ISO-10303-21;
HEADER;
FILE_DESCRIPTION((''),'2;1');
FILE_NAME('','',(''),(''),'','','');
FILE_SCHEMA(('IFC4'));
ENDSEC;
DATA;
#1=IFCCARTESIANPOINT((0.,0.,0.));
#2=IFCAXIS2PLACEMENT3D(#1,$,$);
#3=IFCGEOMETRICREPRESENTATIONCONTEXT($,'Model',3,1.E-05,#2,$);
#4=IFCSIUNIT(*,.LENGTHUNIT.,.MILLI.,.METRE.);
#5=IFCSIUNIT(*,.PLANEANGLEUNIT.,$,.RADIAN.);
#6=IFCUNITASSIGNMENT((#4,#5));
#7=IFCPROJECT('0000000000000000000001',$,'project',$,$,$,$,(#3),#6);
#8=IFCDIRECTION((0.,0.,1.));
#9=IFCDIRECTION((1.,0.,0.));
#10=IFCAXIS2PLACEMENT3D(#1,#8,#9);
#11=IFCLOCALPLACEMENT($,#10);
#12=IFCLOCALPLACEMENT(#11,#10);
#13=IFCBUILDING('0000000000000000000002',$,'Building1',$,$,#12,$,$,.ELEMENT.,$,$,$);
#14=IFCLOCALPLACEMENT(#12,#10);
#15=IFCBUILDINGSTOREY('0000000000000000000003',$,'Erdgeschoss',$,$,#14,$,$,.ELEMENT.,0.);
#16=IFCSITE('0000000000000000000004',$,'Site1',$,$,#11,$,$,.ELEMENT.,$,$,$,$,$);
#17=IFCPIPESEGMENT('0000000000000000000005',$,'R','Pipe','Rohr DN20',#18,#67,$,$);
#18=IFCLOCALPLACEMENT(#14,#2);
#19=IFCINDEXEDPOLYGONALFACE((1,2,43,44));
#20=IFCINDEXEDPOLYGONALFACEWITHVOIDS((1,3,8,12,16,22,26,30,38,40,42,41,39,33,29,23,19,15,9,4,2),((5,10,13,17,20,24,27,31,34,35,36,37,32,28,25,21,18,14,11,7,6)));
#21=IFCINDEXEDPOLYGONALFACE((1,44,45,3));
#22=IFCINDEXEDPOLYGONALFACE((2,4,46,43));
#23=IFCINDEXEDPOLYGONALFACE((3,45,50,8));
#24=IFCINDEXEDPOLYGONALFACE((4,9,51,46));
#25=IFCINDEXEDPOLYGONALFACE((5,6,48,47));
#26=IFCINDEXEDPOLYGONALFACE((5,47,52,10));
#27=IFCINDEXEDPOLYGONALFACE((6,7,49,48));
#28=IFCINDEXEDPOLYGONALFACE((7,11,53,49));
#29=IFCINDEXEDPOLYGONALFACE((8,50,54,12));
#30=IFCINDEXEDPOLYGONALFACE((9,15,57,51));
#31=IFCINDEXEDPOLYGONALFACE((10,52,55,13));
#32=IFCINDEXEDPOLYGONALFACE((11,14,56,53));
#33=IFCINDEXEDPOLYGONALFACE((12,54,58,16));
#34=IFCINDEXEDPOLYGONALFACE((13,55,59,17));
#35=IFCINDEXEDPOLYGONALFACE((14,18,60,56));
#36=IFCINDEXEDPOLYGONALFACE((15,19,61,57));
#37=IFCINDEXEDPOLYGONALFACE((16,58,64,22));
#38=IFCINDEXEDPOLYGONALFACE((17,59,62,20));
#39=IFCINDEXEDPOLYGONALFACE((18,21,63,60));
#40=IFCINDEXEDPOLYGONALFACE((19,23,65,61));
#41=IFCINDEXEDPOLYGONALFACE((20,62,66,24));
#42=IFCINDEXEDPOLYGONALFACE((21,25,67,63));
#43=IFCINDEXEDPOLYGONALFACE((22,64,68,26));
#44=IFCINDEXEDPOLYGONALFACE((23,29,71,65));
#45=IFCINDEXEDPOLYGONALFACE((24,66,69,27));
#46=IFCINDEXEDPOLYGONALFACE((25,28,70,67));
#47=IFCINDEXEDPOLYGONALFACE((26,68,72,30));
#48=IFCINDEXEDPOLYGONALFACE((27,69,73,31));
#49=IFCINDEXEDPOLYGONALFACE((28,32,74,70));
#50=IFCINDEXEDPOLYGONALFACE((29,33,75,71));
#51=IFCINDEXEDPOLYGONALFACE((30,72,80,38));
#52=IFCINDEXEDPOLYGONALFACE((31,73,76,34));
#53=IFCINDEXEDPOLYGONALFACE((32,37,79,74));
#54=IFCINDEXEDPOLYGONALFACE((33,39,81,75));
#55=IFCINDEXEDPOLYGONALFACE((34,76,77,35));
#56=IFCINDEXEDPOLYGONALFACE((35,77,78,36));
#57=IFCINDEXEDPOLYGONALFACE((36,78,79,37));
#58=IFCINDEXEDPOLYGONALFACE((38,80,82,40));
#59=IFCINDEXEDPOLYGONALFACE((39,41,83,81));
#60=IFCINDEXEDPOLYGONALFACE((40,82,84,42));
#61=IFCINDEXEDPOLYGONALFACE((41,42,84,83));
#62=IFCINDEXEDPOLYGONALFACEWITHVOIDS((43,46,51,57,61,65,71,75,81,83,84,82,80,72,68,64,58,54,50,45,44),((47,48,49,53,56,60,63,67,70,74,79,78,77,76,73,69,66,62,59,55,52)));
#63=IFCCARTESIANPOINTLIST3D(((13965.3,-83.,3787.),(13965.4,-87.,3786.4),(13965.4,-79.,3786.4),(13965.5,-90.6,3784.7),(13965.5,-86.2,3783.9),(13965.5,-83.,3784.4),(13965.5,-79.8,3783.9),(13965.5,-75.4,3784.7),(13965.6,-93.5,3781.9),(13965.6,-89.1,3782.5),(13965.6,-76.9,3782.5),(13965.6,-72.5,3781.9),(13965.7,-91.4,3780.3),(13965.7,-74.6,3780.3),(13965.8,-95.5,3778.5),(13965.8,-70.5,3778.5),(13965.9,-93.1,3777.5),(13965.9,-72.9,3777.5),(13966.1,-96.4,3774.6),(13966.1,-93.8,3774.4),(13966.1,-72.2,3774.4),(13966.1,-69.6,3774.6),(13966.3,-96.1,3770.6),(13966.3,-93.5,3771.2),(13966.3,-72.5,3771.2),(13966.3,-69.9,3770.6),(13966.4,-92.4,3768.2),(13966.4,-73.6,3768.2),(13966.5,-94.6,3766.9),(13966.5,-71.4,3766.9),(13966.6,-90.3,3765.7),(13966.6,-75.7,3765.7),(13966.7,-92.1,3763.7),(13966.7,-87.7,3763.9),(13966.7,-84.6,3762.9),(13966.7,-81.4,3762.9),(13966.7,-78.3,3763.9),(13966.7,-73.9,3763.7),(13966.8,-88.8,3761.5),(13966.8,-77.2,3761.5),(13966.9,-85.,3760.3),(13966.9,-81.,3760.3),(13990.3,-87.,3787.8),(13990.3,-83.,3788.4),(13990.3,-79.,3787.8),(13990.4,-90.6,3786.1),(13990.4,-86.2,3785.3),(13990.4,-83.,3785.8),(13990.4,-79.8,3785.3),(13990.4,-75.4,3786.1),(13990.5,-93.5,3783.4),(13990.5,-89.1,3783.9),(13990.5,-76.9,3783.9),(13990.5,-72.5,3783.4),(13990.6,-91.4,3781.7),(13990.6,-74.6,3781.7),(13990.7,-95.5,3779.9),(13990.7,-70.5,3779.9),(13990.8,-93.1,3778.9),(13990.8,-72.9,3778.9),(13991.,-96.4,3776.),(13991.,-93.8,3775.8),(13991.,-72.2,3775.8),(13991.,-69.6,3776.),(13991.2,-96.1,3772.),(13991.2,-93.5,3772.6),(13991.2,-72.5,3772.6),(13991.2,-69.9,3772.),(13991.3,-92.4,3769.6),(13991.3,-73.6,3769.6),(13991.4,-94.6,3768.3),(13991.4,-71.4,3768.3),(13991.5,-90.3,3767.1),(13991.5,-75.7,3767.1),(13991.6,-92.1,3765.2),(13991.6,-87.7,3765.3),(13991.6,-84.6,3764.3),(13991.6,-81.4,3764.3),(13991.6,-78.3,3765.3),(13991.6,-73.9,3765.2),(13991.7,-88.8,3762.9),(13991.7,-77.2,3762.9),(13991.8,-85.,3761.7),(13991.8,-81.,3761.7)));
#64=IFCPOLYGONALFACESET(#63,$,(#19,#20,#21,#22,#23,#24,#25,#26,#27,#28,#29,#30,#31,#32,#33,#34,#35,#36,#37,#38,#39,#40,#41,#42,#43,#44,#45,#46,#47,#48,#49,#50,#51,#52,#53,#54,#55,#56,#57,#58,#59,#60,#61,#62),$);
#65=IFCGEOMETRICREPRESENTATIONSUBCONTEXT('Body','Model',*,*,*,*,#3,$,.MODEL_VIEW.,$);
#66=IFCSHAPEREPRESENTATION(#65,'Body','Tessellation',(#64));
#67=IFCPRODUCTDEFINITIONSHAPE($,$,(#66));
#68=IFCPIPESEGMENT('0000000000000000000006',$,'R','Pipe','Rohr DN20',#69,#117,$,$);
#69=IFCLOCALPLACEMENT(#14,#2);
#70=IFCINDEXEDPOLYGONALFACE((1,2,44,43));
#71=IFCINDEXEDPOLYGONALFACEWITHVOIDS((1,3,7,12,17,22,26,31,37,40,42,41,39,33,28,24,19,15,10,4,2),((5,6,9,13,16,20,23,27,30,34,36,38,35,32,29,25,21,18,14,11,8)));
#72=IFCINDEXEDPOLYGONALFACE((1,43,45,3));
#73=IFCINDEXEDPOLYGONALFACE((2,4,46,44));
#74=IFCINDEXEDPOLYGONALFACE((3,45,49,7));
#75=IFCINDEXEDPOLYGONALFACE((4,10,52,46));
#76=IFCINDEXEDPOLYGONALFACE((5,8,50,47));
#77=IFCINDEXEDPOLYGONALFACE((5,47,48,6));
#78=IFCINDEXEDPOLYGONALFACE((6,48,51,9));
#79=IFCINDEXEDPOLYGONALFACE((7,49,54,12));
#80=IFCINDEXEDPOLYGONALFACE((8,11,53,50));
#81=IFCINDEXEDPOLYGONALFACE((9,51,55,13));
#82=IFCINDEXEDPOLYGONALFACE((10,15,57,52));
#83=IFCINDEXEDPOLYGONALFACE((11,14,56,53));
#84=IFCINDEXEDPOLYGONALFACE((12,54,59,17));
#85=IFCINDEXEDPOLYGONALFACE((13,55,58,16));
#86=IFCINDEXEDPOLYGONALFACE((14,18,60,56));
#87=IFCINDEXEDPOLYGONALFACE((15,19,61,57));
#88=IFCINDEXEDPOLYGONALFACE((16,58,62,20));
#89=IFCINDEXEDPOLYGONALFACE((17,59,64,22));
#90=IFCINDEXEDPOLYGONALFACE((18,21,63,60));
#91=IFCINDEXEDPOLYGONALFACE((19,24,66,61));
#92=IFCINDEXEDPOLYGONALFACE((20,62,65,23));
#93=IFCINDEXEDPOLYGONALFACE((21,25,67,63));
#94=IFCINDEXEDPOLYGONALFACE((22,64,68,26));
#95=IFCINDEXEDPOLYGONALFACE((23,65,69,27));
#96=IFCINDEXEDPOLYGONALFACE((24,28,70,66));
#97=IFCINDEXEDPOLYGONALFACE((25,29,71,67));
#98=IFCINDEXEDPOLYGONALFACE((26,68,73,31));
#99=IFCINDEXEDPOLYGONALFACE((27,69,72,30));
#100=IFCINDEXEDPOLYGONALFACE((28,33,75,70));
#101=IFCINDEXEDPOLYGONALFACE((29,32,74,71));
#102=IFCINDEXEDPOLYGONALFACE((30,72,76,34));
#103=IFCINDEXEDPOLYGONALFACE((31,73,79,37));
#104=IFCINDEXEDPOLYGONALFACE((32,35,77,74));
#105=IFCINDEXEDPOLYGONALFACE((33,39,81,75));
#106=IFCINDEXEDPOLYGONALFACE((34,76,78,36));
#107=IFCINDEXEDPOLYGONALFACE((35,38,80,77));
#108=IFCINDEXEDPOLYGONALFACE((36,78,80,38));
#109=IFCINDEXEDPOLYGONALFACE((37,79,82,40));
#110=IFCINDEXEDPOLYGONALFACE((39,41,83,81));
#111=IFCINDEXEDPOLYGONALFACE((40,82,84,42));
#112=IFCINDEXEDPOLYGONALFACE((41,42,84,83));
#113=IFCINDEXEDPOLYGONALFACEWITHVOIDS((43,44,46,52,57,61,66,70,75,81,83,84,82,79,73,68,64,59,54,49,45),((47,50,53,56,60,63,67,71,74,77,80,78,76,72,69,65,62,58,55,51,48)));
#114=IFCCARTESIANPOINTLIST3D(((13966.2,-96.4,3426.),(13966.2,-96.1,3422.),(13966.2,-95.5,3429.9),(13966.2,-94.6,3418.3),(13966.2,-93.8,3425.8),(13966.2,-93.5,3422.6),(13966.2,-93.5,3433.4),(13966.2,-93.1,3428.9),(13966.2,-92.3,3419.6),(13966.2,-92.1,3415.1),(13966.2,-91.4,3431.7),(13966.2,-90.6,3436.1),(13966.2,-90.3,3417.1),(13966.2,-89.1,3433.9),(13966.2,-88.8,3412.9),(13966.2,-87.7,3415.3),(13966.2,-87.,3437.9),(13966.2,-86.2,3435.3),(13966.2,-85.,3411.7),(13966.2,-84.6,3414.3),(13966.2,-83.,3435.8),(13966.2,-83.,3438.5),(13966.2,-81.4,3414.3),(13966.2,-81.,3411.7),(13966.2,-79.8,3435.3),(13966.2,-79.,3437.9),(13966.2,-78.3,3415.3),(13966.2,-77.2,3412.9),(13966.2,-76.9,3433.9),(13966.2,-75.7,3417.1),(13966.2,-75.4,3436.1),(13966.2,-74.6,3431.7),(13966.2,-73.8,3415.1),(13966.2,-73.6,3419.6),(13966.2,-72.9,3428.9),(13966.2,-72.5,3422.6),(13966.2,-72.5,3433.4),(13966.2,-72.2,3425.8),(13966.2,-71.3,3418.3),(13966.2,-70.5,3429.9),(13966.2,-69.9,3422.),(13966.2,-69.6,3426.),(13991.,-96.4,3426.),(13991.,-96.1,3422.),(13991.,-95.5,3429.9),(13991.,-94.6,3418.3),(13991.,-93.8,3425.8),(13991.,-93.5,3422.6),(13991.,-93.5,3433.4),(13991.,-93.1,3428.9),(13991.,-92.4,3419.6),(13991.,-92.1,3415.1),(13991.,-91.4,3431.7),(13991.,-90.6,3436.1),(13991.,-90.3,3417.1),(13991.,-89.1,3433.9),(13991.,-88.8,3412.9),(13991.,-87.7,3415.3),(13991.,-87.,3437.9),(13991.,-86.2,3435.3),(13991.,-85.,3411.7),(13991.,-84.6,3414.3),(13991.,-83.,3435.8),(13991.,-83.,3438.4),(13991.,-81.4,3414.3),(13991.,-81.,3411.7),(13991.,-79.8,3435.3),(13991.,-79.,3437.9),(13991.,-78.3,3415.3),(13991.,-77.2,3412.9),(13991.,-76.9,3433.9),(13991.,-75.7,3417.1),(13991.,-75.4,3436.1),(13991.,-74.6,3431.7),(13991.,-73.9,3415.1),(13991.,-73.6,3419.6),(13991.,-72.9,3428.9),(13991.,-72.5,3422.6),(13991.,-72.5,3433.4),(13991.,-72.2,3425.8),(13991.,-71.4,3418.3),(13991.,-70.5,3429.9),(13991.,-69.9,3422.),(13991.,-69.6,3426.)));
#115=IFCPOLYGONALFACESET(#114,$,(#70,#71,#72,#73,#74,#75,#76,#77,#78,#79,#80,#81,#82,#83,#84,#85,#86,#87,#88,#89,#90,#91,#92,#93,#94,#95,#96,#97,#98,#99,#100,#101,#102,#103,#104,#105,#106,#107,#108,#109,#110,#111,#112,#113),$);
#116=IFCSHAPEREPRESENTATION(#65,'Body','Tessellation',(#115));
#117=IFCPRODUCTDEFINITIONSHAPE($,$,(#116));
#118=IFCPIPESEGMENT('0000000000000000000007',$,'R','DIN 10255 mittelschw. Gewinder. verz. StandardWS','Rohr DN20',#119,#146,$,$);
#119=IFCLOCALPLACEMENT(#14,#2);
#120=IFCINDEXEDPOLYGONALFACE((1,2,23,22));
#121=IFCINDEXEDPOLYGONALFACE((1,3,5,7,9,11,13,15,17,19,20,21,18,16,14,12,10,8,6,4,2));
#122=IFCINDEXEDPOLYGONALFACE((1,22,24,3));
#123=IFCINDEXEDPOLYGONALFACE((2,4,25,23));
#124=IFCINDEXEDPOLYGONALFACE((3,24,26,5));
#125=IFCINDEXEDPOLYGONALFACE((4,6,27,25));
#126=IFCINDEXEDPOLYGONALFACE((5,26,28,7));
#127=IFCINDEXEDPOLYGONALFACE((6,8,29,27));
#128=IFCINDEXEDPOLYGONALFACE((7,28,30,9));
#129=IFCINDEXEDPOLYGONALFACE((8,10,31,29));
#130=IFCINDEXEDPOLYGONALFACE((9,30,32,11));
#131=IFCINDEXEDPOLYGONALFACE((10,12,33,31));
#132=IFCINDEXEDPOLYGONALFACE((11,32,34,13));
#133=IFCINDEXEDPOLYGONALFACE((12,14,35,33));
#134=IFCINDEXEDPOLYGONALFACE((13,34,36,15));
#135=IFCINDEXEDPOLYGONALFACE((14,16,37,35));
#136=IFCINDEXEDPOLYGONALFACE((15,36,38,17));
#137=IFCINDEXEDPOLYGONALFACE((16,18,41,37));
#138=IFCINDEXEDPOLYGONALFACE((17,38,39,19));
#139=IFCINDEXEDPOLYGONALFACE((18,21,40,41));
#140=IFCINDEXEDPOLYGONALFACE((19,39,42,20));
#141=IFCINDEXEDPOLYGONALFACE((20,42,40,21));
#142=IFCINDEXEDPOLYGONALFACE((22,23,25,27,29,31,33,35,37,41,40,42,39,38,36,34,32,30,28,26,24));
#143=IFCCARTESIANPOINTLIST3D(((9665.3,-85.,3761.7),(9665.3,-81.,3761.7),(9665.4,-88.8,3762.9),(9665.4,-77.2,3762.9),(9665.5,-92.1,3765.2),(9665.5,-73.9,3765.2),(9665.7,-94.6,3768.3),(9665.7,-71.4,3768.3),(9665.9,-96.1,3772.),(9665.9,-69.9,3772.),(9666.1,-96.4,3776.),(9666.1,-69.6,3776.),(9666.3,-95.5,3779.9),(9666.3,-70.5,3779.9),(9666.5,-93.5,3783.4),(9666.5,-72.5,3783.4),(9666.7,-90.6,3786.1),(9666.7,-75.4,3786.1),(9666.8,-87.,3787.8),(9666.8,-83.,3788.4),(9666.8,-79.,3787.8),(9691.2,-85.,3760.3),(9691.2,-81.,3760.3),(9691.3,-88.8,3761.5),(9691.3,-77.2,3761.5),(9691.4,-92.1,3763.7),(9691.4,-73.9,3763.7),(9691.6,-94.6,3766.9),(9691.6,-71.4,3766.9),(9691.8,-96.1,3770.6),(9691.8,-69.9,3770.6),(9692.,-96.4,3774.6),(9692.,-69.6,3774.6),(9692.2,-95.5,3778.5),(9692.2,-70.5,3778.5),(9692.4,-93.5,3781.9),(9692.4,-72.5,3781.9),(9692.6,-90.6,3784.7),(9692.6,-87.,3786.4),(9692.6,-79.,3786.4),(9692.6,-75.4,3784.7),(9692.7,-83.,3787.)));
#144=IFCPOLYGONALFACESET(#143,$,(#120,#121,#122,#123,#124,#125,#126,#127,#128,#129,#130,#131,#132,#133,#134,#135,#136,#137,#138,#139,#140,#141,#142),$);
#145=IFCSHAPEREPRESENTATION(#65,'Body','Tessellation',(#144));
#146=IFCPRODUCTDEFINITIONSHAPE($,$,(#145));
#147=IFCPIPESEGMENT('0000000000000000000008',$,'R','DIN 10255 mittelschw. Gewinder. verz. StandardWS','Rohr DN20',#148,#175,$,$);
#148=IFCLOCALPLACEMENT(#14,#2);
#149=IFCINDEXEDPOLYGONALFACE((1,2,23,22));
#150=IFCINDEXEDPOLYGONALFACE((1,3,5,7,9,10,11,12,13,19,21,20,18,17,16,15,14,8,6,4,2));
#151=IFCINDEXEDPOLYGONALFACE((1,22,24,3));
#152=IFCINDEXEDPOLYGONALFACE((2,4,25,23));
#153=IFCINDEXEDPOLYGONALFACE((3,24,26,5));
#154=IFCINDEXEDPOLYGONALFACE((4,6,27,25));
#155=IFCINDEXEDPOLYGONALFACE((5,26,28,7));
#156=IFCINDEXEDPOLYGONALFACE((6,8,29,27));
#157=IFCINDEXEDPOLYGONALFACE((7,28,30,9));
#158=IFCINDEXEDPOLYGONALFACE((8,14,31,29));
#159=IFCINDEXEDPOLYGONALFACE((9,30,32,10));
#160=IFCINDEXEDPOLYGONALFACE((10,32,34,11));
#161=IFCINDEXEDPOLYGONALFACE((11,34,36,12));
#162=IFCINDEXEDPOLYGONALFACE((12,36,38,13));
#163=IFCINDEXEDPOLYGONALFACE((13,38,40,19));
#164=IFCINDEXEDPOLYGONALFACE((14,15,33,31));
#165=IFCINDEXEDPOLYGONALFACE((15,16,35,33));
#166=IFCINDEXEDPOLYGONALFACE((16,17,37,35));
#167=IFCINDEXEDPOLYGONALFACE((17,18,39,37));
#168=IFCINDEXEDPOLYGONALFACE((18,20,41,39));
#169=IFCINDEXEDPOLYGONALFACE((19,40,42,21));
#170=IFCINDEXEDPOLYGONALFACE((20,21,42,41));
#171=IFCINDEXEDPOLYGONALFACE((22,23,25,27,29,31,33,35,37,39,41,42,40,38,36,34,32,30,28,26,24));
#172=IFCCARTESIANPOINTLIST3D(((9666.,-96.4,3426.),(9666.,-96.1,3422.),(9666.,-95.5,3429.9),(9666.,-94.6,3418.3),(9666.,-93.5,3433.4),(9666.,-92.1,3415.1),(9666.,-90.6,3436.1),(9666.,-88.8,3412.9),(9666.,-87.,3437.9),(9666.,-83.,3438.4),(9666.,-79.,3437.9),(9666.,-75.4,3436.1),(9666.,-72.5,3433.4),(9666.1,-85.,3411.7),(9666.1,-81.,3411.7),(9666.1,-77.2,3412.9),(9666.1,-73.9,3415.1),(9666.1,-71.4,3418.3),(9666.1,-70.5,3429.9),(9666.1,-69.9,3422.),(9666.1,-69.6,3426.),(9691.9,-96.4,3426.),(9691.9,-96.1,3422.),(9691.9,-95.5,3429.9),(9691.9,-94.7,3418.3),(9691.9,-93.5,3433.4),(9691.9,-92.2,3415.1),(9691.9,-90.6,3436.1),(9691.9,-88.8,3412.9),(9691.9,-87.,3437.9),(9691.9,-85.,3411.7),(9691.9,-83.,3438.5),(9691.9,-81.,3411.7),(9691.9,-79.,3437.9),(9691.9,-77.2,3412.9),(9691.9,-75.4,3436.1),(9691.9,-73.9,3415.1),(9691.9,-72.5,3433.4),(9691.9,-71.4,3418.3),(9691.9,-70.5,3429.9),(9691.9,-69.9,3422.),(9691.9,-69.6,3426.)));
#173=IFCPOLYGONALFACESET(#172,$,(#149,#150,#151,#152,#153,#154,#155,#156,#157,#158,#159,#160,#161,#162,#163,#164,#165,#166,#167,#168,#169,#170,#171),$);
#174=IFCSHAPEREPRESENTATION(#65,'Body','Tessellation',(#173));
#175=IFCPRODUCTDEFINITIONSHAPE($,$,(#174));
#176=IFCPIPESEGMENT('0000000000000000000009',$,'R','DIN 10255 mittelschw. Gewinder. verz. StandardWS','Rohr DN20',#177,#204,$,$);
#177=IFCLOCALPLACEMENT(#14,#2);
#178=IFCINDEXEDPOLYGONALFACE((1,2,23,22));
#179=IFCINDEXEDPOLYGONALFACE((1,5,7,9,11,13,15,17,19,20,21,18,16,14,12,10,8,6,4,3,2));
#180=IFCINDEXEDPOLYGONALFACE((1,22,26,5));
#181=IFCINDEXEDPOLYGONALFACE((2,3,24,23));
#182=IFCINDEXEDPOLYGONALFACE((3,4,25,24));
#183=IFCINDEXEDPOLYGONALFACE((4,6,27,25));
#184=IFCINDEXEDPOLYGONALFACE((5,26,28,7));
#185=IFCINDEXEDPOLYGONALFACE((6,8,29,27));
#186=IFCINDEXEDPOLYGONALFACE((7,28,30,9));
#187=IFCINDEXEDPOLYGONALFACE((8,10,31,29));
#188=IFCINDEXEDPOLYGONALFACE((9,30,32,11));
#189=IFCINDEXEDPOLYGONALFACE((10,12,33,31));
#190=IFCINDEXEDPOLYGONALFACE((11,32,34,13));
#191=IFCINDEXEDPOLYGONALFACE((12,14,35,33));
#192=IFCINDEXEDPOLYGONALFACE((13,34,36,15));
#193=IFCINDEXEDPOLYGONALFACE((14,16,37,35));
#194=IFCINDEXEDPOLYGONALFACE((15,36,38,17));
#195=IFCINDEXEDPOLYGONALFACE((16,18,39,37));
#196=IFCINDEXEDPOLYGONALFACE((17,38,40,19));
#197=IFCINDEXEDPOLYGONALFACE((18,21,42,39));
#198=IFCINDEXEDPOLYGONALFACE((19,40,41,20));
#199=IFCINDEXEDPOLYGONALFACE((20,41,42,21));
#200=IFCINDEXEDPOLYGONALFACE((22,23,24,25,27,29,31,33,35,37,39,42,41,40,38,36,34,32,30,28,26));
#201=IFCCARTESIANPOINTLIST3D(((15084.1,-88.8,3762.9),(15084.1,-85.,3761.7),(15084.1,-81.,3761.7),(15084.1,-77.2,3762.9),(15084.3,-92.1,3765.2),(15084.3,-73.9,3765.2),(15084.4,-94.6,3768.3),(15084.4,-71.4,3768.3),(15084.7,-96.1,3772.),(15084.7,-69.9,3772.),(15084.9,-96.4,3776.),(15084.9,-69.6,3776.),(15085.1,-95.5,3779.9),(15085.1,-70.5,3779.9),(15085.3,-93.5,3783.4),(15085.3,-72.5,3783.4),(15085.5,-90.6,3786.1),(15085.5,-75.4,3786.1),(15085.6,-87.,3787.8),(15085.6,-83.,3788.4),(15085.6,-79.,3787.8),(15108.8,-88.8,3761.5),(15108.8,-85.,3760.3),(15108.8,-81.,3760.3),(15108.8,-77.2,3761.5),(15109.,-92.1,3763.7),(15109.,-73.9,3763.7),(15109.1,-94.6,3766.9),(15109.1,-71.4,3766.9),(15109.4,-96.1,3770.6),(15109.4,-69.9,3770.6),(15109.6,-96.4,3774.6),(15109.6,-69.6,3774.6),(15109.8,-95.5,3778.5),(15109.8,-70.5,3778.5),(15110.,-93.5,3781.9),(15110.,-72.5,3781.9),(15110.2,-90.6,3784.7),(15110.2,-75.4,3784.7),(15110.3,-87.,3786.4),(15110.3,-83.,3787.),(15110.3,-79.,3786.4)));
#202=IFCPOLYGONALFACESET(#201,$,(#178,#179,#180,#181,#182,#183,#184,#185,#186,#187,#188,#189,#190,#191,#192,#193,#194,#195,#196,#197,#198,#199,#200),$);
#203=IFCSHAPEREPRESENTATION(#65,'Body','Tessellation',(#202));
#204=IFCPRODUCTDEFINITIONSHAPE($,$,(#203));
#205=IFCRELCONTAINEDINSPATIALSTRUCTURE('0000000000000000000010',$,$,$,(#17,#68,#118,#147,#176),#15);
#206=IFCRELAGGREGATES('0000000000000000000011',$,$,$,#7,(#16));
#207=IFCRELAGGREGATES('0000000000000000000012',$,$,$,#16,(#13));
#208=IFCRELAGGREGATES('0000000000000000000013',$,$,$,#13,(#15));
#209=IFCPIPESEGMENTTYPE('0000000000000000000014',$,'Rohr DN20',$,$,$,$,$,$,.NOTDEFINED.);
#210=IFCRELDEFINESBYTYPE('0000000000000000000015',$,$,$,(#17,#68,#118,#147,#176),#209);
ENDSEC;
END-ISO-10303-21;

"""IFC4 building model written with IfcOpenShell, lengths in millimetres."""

from ifc_helpers import new_model, si_unit, frame, origin, origin_with_axes, origin_2d_with_axis, place, context, subcontext, project, spatial, circle, hollow_circle, extrude, type_object, element, save


model = new_model("IFC4")

# Units and contexts
model_context = context("Model", 3, precision=1e-05, world=origin())
body_context = subcontext(model_context, "Body", "Model", "MODEL_VIEW")
ifc_project = project(units=[si_unit("LENGTHUNIT", "METRE", prefix="MILLI"), si_unit("PLANEANGLEUNIT", "RADIAN")], contexts=[model_context])

# Site, building, storey
site_placement = place(None, origin_with_axes())
site = spatial("IfcSite", under=ifc_project, at=site_placement, Name="Site1", CompositionType="ELEMENT")
building_placement = place(site_placement, origin_with_axes())
building = spatial("IfcBuilding", under=site, at=building_placement, Name="Building1", CompositionType="ELEMENT")
storey_placement = place(building_placement, origin_with_axes())
storey = spatial("IfcBuildingStorey", under=building, at=storey_placement, Name="Erdgeschoss", CompositionType="ELEMENT", Elevation=0.0)

# Pipe segments
pipe_segment_type_1 = type_object("IfcPipeSegmentType", Name="Rohr DN20", PredefinedType="NOTDEFINED")
pipe_segment_1_placement = place(storey_placement, frame((13978.6, -82.8, 3774.3), z_axis=(0.0, 0.0, 1.0), x_axis=(1.0, 0.0, 0.0)))
element("IfcPipeSegment", 1, at=pipe_segment_1_placement, inside=storey, type_object=pipe_segment_type_1, Name="R", Description="Pipe", ObjectType="Rohr DN20", context=body_context, shape_type="SolidModel", body=[
    extrude(hollow_circle(Radius=13.4, WallThickness=2.6, at=origin_2d_with_axis()), frame((-12.5, -0.1, -0.7), z_axis=(0.998368, 0.0, 0.057114), x_axis=(0.0, 0.0, 1.0)), (0.0, 0.0, 1.0), 24.9),
])
pipe_segment_2_placement = place(storey_placement, frame((13978.6, -82.8, 3425.0), z_axis=(0.0, 0.0, 1.0), x_axis=(1.0, 0.0, 0.0)))
element("IfcPipeSegment", 2, at=pipe_segment_2_placement, inside=storey, type_object=pipe_segment_type_1, Name="R", Description="Pipe", ObjectType="Rohr DN20", context=body_context, shape_type="SolidModel", body=[
    extrude(hollow_circle(Radius=13.4, WallThickness=2.6, at=origin_2d_with_axis()), frame((-12.4, -0.1, 0.0), z_axis=(1.0, -0.000132, -0.000095), x_axis=(0.0, 0.0, 1.0)), (0.0, 0.0, 1.0), 24.9),
])
pipe_segment_3_placement = place(storey_placement, frame((9679.0, -83.2, 3774.3), z_axis=(0.0, 0.0, 1.0), x_axis=(1.0, 0.0, 0.0)))
element("IfcPipeSegment", 3, at=pipe_segment_3_placement, inside=storey, type_object=pipe_segment_type_1, Name="R", Description="DIN 10255 mittelschw. Gewinder. verz. StandardWS", ObjectType="Rohr DN20", context=body_context, shape_type="SolidModel", body=[
    extrude(circle(Radius=13.4, at=origin_2d_with_axis()), frame((12.9, 0.1, -0.7), z_axis=(-0.99849, 0.0, 0.054935), x_axis=(0.0, 0.0, 1.0)), (0.0, 0.0, 1.0), 25.9),
])
pipe_segment_4_placement = place(storey_placement, frame((9679.0, -83.2, 3425.0), z_axis=(0.0, 0.0, 1.0), x_axis=(1.0, 0.0, 0.0)))
element("IfcPipeSegment", 4, at=pipe_segment_4_placement, inside=storey, type_object=pipe_segment_type_1, Name="R", Description="DIN 10255 mittelschw. Gewinder. verz. StandardWS", ObjectType="Rohr DN20", context=body_context, shape_type="SolidModel", body=[
    extrude(circle(Radius=13.4, at=origin_2d_with_axis()), frame((12.9, 0.1, 0.0), z_axis=(-1.0, 0.000127, -0.000091), x_axis=(0.0, 0.0, 1.0)), (0.0, 0.0, 1.0), 25.8),
])
pipe_segment_5_placement = place(storey_placement, frame((15097.2, -83.2, 3774.3), z_axis=(0.0, 0.0, 1.0), x_axis=(1.0, 0.0, 0.0)))
element("IfcPipeSegment", 5, at=pipe_segment_5_placement, inside=storey, type_object=pipe_segment_type_1, Name="R", Description="DIN 10255 mittelschw. Gewinder. verz. StandardWS", ObjectType="Rohr DN20", context=body_context, shape_type="SolidModel", body=[
    extrude(circle(Radius=13.4, at=origin_2d_with_axis()), frame((12.4, 0.1, -0.7), z_axis=(-0.998342, 0.0, 0.057556), x_axis=(0.0, 0.0, 1.0)), (0.0, 0.0, 1.0), 24.8),
])

save(model, "model.ifc")
